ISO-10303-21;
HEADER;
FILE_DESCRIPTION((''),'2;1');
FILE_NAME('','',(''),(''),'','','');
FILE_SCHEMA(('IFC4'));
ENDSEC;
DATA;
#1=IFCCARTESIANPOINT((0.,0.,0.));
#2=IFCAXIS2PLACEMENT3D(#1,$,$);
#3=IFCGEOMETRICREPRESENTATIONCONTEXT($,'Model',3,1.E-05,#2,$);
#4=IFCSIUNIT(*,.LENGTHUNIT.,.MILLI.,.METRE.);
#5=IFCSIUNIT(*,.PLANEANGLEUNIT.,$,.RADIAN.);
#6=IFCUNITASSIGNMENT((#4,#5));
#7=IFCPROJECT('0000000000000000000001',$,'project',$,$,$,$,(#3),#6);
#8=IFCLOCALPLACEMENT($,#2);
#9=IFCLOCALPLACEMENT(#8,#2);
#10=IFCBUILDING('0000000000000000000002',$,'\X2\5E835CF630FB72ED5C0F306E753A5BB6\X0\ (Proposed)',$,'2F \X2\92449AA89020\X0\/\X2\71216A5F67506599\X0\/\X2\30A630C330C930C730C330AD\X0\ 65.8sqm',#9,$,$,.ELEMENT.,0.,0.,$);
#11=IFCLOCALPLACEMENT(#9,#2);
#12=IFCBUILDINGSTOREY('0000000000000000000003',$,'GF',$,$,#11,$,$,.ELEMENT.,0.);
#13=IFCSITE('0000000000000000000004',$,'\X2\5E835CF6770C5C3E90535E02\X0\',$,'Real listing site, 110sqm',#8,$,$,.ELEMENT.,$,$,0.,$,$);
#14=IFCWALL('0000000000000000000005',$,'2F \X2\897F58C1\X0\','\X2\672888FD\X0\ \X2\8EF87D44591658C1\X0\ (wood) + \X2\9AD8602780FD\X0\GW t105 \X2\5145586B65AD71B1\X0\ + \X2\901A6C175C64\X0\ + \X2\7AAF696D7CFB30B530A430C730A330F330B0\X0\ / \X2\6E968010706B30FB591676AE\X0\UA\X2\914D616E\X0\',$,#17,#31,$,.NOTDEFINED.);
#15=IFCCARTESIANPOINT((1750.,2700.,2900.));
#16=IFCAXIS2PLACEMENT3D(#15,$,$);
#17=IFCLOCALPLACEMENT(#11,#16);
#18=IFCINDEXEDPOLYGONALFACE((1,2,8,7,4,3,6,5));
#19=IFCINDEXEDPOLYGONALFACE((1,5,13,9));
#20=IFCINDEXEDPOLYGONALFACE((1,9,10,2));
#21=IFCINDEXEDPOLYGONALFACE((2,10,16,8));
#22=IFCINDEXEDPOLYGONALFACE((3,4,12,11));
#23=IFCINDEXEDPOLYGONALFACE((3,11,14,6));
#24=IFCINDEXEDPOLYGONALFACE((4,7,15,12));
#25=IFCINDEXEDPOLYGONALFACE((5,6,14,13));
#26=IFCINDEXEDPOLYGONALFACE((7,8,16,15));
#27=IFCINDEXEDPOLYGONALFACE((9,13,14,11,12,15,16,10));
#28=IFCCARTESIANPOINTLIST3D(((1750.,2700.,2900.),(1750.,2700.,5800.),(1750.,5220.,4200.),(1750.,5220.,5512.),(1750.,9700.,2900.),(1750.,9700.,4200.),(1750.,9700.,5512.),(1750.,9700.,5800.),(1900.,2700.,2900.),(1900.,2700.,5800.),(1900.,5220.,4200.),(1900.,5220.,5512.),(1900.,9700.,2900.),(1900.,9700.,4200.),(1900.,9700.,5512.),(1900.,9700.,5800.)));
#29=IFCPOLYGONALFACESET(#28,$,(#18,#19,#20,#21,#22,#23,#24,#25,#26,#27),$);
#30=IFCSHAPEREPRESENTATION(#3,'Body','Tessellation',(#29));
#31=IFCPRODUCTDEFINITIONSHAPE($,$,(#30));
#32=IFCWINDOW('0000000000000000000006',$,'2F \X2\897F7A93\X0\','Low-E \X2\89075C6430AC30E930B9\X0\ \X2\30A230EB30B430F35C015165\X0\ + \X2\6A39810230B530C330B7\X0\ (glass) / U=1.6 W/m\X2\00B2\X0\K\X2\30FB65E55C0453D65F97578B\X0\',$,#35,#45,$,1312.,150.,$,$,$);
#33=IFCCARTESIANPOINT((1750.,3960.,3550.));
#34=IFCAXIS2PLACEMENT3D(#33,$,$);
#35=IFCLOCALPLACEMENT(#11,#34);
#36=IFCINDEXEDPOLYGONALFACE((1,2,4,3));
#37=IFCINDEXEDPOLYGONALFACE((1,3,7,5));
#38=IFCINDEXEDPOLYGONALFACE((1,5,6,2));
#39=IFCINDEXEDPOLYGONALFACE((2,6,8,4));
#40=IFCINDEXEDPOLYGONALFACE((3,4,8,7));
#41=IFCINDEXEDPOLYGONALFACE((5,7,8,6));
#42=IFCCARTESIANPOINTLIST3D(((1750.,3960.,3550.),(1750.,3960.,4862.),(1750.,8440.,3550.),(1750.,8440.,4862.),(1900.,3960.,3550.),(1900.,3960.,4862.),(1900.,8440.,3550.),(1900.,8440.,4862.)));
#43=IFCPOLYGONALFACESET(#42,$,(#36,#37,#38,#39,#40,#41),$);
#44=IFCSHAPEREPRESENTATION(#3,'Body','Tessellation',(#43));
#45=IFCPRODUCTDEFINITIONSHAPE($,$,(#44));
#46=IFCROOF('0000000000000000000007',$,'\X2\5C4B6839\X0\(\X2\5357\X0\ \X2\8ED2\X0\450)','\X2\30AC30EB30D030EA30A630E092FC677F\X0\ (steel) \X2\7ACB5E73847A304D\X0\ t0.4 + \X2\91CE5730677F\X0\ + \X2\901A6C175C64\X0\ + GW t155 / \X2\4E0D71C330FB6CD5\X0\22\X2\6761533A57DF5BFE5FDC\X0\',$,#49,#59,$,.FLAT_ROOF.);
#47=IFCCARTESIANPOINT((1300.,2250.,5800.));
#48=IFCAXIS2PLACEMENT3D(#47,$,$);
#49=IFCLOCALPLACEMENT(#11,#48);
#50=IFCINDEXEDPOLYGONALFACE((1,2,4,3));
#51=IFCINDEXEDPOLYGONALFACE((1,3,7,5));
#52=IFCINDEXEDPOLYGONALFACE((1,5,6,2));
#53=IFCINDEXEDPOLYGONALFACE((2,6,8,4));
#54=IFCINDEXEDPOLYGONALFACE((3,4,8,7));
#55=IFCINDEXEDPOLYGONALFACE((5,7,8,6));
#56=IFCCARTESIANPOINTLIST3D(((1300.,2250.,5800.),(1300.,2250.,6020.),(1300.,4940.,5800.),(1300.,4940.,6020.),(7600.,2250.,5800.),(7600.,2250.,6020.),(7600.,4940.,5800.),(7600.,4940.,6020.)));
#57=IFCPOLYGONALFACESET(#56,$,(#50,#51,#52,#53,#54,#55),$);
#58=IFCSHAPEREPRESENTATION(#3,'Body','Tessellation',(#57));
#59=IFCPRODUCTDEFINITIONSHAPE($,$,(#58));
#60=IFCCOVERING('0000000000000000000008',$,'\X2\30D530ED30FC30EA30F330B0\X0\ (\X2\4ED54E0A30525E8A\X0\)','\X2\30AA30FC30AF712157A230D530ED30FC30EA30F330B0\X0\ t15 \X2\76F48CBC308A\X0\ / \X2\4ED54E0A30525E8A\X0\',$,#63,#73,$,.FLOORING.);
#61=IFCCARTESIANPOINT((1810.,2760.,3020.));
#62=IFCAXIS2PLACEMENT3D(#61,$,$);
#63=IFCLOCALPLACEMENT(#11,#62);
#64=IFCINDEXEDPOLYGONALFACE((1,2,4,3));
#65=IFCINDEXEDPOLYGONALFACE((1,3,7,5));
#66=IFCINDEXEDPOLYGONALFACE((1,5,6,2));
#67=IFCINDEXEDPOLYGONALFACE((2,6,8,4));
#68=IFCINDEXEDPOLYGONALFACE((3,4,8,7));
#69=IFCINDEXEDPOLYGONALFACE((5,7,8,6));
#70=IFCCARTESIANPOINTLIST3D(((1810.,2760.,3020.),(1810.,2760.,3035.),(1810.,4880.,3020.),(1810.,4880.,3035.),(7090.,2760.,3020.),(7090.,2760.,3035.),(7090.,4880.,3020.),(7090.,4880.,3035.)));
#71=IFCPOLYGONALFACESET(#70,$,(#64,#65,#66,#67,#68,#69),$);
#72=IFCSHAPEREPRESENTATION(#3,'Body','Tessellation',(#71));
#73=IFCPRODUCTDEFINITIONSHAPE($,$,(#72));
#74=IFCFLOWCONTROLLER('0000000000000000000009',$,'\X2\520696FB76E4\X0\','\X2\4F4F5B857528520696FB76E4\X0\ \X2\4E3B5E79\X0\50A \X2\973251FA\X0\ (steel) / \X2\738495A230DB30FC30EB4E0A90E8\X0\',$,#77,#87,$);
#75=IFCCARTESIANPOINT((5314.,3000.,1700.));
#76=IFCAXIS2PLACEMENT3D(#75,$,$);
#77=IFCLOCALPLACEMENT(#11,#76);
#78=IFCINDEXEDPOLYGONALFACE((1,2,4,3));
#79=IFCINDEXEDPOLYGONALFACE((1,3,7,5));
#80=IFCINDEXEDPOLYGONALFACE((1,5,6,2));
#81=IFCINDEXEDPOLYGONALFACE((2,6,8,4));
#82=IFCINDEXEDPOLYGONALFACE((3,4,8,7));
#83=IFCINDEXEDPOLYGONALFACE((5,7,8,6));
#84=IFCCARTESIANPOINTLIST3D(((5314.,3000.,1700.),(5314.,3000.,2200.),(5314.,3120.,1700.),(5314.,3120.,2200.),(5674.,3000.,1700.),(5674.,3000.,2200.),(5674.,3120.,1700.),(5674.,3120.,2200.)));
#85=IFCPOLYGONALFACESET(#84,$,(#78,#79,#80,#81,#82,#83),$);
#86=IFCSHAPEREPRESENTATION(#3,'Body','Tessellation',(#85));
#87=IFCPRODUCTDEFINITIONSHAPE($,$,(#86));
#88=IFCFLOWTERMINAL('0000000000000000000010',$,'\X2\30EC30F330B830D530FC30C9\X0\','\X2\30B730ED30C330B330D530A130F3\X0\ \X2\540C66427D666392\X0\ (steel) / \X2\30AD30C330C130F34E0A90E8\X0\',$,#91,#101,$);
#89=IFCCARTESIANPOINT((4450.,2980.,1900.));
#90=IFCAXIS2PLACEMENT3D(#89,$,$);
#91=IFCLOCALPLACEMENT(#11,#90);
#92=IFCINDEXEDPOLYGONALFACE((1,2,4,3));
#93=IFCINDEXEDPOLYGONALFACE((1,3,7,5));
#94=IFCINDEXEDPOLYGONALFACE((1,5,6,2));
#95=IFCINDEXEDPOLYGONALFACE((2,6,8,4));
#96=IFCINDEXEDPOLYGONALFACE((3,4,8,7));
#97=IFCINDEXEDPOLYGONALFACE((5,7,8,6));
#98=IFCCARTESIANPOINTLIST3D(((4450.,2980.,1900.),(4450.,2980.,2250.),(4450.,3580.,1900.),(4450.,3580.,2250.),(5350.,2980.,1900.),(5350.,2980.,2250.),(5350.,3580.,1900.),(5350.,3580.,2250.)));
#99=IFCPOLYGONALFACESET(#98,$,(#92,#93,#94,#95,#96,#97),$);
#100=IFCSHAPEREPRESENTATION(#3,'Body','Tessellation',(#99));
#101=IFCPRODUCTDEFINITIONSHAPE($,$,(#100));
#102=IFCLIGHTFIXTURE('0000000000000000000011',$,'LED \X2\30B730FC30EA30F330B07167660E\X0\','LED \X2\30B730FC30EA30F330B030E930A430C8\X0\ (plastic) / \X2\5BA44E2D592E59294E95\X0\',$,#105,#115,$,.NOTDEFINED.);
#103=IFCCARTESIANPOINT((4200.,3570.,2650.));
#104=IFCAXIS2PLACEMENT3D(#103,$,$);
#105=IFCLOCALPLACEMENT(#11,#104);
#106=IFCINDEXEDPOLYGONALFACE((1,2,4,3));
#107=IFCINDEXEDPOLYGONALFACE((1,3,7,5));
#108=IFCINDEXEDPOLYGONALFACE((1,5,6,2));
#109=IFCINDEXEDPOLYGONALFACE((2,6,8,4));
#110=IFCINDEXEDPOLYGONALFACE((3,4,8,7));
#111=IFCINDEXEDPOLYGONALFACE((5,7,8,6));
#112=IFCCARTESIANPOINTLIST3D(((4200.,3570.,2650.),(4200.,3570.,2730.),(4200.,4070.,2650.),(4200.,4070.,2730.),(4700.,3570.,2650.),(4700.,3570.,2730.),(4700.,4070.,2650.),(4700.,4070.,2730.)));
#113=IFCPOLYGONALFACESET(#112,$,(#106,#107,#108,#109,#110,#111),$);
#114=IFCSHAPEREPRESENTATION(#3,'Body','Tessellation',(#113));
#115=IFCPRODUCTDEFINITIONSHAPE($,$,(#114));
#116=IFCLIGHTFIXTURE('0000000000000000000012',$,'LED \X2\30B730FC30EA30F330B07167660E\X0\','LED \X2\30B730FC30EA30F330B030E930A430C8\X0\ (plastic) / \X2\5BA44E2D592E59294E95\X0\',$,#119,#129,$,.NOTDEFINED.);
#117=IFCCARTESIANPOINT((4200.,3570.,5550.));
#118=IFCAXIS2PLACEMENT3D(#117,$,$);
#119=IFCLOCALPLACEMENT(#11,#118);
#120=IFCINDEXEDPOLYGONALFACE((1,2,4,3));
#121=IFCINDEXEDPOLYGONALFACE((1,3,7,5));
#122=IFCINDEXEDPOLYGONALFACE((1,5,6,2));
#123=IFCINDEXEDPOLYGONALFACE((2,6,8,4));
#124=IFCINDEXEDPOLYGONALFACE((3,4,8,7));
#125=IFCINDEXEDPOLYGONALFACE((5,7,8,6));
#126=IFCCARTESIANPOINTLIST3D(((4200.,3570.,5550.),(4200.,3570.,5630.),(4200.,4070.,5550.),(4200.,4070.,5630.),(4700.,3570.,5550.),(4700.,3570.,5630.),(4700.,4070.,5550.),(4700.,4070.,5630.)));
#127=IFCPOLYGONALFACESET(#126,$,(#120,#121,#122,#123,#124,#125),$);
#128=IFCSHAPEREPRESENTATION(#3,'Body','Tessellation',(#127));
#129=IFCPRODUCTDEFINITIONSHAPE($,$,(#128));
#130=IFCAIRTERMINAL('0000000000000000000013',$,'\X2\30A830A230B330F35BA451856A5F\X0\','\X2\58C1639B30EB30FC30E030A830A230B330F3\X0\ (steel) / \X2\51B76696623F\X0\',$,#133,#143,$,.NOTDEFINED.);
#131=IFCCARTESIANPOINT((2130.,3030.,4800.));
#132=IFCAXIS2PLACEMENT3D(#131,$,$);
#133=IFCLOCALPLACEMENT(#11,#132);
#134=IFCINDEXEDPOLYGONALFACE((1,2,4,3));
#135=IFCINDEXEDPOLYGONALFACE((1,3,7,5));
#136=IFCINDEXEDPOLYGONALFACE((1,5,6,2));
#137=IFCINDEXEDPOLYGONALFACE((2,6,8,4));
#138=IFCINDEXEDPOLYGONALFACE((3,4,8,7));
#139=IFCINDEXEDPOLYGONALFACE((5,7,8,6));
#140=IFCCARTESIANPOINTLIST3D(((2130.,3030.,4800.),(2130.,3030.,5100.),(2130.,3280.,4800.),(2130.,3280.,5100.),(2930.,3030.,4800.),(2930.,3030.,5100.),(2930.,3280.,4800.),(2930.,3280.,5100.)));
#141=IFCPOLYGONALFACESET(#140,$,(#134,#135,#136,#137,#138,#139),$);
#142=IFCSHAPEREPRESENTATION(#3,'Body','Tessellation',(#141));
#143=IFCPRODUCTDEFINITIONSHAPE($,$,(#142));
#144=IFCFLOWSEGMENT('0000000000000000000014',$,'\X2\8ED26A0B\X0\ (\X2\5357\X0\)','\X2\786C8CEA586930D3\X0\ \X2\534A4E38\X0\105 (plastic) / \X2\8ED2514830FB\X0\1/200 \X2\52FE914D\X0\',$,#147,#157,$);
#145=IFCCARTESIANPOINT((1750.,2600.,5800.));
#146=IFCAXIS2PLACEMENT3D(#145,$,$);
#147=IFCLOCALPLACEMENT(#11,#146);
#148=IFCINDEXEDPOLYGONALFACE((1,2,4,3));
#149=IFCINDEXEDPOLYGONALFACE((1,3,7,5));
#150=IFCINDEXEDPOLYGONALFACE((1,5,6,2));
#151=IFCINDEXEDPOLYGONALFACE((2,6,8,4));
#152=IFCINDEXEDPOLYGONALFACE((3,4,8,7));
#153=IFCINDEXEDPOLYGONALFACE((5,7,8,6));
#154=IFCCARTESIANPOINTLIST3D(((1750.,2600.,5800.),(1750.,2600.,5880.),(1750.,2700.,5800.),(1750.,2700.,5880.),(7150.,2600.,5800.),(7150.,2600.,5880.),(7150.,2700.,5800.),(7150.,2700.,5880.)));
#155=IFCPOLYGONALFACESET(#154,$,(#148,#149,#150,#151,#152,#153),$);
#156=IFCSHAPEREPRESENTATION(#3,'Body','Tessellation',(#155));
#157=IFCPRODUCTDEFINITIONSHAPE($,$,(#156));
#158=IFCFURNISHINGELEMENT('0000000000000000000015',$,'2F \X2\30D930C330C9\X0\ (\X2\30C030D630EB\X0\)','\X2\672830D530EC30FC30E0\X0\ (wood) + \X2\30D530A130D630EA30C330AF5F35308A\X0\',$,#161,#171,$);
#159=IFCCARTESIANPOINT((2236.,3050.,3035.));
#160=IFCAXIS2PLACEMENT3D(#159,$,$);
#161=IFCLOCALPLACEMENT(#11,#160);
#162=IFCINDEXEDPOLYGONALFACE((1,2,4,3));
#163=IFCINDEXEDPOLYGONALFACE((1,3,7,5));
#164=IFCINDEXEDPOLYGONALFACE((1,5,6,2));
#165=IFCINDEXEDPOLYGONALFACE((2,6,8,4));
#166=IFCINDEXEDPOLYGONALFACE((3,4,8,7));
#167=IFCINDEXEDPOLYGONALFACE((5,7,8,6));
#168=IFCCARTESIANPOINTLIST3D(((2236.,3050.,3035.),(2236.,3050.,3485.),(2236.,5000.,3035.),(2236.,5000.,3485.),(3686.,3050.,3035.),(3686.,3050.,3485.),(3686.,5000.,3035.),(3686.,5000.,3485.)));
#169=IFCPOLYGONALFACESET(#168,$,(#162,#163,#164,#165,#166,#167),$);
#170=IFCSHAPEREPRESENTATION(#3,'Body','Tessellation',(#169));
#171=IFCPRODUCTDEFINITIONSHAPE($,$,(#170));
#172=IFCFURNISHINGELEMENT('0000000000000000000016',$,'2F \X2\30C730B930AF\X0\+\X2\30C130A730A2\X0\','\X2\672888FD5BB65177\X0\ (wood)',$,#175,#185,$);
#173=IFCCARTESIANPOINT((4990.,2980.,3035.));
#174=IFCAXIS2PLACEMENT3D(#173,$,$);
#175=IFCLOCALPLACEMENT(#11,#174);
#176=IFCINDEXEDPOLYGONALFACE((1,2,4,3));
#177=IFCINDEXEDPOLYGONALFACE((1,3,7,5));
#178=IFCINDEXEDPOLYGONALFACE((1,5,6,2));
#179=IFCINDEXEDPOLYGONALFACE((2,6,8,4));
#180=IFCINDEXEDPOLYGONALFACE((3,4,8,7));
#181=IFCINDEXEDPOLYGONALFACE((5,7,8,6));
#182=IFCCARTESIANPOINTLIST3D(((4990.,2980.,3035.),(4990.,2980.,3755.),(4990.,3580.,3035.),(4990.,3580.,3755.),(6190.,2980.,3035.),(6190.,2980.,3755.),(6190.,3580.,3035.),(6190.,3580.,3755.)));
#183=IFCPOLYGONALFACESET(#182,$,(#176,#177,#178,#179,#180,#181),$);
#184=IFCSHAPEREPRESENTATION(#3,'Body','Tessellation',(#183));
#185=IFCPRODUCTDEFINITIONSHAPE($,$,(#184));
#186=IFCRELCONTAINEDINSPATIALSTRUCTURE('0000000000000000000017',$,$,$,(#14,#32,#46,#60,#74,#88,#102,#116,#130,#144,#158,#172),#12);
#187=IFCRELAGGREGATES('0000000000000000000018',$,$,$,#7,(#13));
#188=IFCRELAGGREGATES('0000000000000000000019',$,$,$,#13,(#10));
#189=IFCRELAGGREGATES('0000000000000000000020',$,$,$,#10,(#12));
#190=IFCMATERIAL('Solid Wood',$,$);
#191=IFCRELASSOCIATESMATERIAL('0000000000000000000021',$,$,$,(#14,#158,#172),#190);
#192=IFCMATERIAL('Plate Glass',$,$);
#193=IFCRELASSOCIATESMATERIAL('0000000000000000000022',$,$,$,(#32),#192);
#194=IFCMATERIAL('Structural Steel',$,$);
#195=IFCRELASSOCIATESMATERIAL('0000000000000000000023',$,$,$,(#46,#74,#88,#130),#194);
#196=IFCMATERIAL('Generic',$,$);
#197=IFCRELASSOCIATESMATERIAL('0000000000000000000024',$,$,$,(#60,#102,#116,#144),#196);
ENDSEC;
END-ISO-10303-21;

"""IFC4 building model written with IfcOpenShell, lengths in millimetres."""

from ifc_helpers import new_model, si_unit, frame, frame_2d, origin, place, context, project, spatial, rectangle, extrude, material, element, fill, save


model = new_model("IFC4")

# Units and contexts
model_context = context("Model", 3, precision=1e-05, world=origin())
ifc_project = project(units=[si_unit("LENGTHUNIT", "METRE", prefix="MILLI"), si_unit("PLANEANGLEUNIT", "RADIAN")], contexts=[model_context])

# Site, building, storey
site_placement = place(None, origin())
site = spatial("IfcSite", under=ifc_project, at=site_placement, Name="広島県尾道市", ObjectType="Real listing site, 110sqm", CompositionType="ELEMENT", RefElevation=0.0)
building_placement = place(site_placement, origin())
building = spatial("IfcBuilding", under=site, at=building_placement, Name="広島・狭小の町家 (Proposed)", ObjectType="2F 鉄骨造/無機材料/ウッドデッキ 65.8sqm", CompositionType="ELEMENT", ElevationOfRefHeight=0.0, ElevationOfTerrain=0.0)
storey_placement = place(building_placement, origin())
storey = spatial("IfcBuildingStorey", under=building, at=storey_placement, Name="GF", CompositionType="ELEMENT", Elevation=0.0)

# Shared definitions
ifc_material_1 = material(Name="Solid Wood")

# Wall, opening, window
ifc_material_2 = material(Name="Plate Glass")
wall_1_placement = place(storey_placement, frame((1750.0, 2700.0, 2900.0)))
wall_1 = element("IfcWall", 1, at=wall_1_placement, inside=storey, material=ifc_material_1, Name="2F 西壁", Description="木製 軸組外壁 (wood) + 高性能GW t105 充填断熱 + 通気層 + 窯業系サイディング / 準耐火・外皮UA配慮", PredefinedType="NOTDEFINED", context=model_context, shape_type="SweptSolid", body=[
    extrude(rectangle(XDim=150.0, YDim=7000.0, at=frame_2d((75.0, 3500.0))), frame((1750.0, 2700.0, 2900.0)), (0.0, 0.0, 1.0), 2900.0),
])
opening_1_placement = place(storey_placement, frame((1750.0, 3960.0, 3550.0)))
opening_1 = element("IfcOpeningElement", 2, at=opening_1_placement, cuts=wall_1, PredefinedType="NOTDEFINED", context=model_context, shape_type="SweptSolid", body=[
    extrude(rectangle(XDim=150.0, YDim=4480.0, at=frame_2d((75.0, 2240.0))), frame((1750.0, 3960.0, 3550.0)), (0.0, 0.0, 1.0), 1312.0),
])
window_1_placement = place(storey_placement, frame((1750.0, 3960.0, 3550.0)))
window_1 = element("IfcWindow", 3, at=window_1_placement, inside=storey, material=ifc_material_2, Name="2F 西窓", Description="Low-E 複層ガラス アルゴン封入 + 樹脂サッシ (glass) / U=1.6 W/m²K・日射取得型", OverallHeight=1312.0, OverallWidth=150.0, context=model_context, shape_type="SweptSolid", body=[
    extrude(rectangle(XDim=150.0, YDim=4480.0, at=frame_2d((75.0, 2240.0))), frame((1750.0, 3960.0, 3550.0)), (0.0, 0.0, 1.0), 1312.0),
])
fill(opening_1, window_1)

# Roof
ifc_material_3 = material(Name="Structural Steel")
for number, where, name in (
    (4, (1300.0, 2250.0, 5800.0), "屋根(南 軒450)"),
):
    element("IfcRoof", number, at=place(storey_placement, frame(where)), inside=storey, material=ifc_material_3, Name=name, Description="ガルバリウム鋼板 (steel) 立平葺き t0.4 + 野地板 + 通気層 + GW t155 / 不燃・法22条区域対応", PredefinedType="FLAT_ROOF", context=model_context, shape_type="SweptSolid", body=[
        extrude(rectangle(XDim=6300.0, YDim=2690.0, at=frame_2d((3150.0, 1345.0))), frame((1300.0, 2250.0, 5800.0)), (0.0, 0.0, 1.0), 220.0),
    ])

# Covering
ifc_material_4 = material(Name="Generic")
covering_placement = place(storey_placement, frame((1810.0, 2760.0, 3020.0)))
element("IfcCovering", 5, at=covering_placement, inside=storey, material=ifc_material_4, Name="フローリング (仕上げ床)", Description="オーク無垢フローリング t15 直貼り / 仕上げ床", PredefinedType="FLOORING", context=model_context, shape_type="SweptSolid", body=[
    extrude(rectangle(XDim=5280.0, YDim=2120.0, at=frame_2d((2640.0, 1060.0))), frame((1810.0, 2760.0, 3020.0)), (0.0, 0.0, 1.0), 15.0),
])

# Flow controller
flow_controller_placement = place(storey_placement, frame((5314.0, 3000.0, 1700.0)))
element("IfcFlowController", 6, at=flow_controller_placement, inside=storey, material=ifc_material_3, Name="分電盤", Description="住宅用分電盤 主幹50A 露出 (steel) / 玄関ホール上部", context=model_context, shape_type="SweptSolid", body=[
    extrude(rectangle(XDim=360.0, YDim=120.0, at=frame_2d((180.0, 60.0))), frame((5314.0, 3000.0, 1700.0)), (0.0, 0.0, 1.0), 500.0),
])

# Flow terminal
flow_terminal_placement = place(storey_placement, frame((4450.0, 2980.0, 1900.0)))
element("IfcFlowTerminal", 7, at=flow_terminal_placement, inside=storey, material=ifc_material_3, Name="レンジフード", Description="シロッコファン 同時給排 (steel) / キッチン上部", context=model_context, shape_type="SweptSolid", body=[
    extrude(rectangle(XDim=900.0, YDim=600.0, at=frame_2d((450.0, 300.0))), frame((4450.0, 2980.0, 1900.0)), (0.0, 0.0, 1.0), 350.0),
])

# Light fixtures
light_fixture_1_placement = place(storey_placement, frame((4200.0, 3570.0, 2650.0)))
element("IfcLightFixture", 8, at=light_fixture_1_placement, inside=storey, material=ifc_material_4, Name="LED シーリング照明", Description="LED シーリングライト (plastic) / 室中央天井", PredefinedType="NOTDEFINED", context=model_context, shape_type="SweptSolid", body=[
    extrude(rectangle(XDim=500.0, YDim=500.0, at=frame_2d((250.0, 250.0))), frame((4200.0, 3570.0, 2650.0)), (0.0, 0.0, 1.0), 80.0),
])
light_fixture_2_placement = place(storey_placement, frame((4200.0, 3570.0, 5550.0)))
element("IfcLightFixture", 9, at=light_fixture_2_placement, inside=storey, material=ifc_material_4, Name="LED シーリング照明", Description="LED シーリングライト (plastic) / 室中央天井", PredefinedType="NOTDEFINED", context=model_context, shape_type="SweptSolid", body=[
    extrude(rectangle(XDim=500.0, YDim=500.0, at=frame_2d((250.0, 250.0))), frame((4200.0, 3570.0, 5550.0)), (0.0, 0.0, 1.0), 80.0),
])

# Air terminal
air_terminal_placement = place(storey_placement, frame((2130.0, 3030.0, 4800.0)))
element("IfcAirTerminal", 10, at=air_terminal_placement, inside=storey, material=ifc_material_3, Name="エアコン室内機", Description="壁掛ルームエアコン (steel) / 冷暖房", PredefinedType="NOTDEFINED", context=model_context, shape_type="SweptSolid", body=[
    extrude(rectangle(XDim=800.0, YDim=250.0, at=frame_2d((400.0, 125.0))), frame((2130.0, 3030.0, 4800.0)), (0.0, 0.0, 1.0), 300.0),
])

# Flow segment
flow_segment_placement = place(storey_placement, frame((1750.0, 2600.0, 5800.0)))
element("IfcFlowSegment", 11, at=flow_segment_placement, inside=storey, material=ifc_material_4, Name="軒樋 (南)", Description="硬質塩ビ 半丸105 (plastic) / 軒先・1/200 勾配", context=model_context, shape_type="SweptSolid", body=[
    extrude(rectangle(XDim=5400.0, YDim=100.0, at=frame_2d((2700.0, 50.0))), frame((1750.0, 2600.0, 5800.0)), (0.0, 0.0, 1.0), 80.0),
])

# Furnishing elements
furnishing_1_placement = place(storey_placement, frame((2236.0, 3050.0, 3035.0)))
element("IfcFurnishingElement", 12, at=furnishing_1_placement, inside=storey, material=ifc_material_1, Name="2F ベッド (ダブル)", Description="木フレーム (wood) + ファブリック張り", context=model_context, shape_type="SweptSolid", body=[
    extrude(rectangle(XDim=1450.0, YDim=1950.0, at=frame_2d((725.0, 975.0))), frame((2236.0, 3050.0, 3035.0)), (0.0, 0.0, 1.0), 450.0),
])
furnishing_2_placement = place(storey_placement, frame((4990.0, 2980.0, 3035.0)))
element("IfcFurnishingElement", 13, at=furnishing_2_placement, inside=storey, material=ifc_material_1, Name="2F デスク+チェア", Description="木製家具 (wood)", context=model_context, shape_type="SweptSolid", body=[
    extrude(rectangle(XDim=1200.0, YDim=600.0, at=frame_2d((600.0, 300.0))), frame((4990.0, 2980.0, 3035.0)), (0.0, 0.0, 1.0), 720.0),
])

save(model, "model.ifc")
